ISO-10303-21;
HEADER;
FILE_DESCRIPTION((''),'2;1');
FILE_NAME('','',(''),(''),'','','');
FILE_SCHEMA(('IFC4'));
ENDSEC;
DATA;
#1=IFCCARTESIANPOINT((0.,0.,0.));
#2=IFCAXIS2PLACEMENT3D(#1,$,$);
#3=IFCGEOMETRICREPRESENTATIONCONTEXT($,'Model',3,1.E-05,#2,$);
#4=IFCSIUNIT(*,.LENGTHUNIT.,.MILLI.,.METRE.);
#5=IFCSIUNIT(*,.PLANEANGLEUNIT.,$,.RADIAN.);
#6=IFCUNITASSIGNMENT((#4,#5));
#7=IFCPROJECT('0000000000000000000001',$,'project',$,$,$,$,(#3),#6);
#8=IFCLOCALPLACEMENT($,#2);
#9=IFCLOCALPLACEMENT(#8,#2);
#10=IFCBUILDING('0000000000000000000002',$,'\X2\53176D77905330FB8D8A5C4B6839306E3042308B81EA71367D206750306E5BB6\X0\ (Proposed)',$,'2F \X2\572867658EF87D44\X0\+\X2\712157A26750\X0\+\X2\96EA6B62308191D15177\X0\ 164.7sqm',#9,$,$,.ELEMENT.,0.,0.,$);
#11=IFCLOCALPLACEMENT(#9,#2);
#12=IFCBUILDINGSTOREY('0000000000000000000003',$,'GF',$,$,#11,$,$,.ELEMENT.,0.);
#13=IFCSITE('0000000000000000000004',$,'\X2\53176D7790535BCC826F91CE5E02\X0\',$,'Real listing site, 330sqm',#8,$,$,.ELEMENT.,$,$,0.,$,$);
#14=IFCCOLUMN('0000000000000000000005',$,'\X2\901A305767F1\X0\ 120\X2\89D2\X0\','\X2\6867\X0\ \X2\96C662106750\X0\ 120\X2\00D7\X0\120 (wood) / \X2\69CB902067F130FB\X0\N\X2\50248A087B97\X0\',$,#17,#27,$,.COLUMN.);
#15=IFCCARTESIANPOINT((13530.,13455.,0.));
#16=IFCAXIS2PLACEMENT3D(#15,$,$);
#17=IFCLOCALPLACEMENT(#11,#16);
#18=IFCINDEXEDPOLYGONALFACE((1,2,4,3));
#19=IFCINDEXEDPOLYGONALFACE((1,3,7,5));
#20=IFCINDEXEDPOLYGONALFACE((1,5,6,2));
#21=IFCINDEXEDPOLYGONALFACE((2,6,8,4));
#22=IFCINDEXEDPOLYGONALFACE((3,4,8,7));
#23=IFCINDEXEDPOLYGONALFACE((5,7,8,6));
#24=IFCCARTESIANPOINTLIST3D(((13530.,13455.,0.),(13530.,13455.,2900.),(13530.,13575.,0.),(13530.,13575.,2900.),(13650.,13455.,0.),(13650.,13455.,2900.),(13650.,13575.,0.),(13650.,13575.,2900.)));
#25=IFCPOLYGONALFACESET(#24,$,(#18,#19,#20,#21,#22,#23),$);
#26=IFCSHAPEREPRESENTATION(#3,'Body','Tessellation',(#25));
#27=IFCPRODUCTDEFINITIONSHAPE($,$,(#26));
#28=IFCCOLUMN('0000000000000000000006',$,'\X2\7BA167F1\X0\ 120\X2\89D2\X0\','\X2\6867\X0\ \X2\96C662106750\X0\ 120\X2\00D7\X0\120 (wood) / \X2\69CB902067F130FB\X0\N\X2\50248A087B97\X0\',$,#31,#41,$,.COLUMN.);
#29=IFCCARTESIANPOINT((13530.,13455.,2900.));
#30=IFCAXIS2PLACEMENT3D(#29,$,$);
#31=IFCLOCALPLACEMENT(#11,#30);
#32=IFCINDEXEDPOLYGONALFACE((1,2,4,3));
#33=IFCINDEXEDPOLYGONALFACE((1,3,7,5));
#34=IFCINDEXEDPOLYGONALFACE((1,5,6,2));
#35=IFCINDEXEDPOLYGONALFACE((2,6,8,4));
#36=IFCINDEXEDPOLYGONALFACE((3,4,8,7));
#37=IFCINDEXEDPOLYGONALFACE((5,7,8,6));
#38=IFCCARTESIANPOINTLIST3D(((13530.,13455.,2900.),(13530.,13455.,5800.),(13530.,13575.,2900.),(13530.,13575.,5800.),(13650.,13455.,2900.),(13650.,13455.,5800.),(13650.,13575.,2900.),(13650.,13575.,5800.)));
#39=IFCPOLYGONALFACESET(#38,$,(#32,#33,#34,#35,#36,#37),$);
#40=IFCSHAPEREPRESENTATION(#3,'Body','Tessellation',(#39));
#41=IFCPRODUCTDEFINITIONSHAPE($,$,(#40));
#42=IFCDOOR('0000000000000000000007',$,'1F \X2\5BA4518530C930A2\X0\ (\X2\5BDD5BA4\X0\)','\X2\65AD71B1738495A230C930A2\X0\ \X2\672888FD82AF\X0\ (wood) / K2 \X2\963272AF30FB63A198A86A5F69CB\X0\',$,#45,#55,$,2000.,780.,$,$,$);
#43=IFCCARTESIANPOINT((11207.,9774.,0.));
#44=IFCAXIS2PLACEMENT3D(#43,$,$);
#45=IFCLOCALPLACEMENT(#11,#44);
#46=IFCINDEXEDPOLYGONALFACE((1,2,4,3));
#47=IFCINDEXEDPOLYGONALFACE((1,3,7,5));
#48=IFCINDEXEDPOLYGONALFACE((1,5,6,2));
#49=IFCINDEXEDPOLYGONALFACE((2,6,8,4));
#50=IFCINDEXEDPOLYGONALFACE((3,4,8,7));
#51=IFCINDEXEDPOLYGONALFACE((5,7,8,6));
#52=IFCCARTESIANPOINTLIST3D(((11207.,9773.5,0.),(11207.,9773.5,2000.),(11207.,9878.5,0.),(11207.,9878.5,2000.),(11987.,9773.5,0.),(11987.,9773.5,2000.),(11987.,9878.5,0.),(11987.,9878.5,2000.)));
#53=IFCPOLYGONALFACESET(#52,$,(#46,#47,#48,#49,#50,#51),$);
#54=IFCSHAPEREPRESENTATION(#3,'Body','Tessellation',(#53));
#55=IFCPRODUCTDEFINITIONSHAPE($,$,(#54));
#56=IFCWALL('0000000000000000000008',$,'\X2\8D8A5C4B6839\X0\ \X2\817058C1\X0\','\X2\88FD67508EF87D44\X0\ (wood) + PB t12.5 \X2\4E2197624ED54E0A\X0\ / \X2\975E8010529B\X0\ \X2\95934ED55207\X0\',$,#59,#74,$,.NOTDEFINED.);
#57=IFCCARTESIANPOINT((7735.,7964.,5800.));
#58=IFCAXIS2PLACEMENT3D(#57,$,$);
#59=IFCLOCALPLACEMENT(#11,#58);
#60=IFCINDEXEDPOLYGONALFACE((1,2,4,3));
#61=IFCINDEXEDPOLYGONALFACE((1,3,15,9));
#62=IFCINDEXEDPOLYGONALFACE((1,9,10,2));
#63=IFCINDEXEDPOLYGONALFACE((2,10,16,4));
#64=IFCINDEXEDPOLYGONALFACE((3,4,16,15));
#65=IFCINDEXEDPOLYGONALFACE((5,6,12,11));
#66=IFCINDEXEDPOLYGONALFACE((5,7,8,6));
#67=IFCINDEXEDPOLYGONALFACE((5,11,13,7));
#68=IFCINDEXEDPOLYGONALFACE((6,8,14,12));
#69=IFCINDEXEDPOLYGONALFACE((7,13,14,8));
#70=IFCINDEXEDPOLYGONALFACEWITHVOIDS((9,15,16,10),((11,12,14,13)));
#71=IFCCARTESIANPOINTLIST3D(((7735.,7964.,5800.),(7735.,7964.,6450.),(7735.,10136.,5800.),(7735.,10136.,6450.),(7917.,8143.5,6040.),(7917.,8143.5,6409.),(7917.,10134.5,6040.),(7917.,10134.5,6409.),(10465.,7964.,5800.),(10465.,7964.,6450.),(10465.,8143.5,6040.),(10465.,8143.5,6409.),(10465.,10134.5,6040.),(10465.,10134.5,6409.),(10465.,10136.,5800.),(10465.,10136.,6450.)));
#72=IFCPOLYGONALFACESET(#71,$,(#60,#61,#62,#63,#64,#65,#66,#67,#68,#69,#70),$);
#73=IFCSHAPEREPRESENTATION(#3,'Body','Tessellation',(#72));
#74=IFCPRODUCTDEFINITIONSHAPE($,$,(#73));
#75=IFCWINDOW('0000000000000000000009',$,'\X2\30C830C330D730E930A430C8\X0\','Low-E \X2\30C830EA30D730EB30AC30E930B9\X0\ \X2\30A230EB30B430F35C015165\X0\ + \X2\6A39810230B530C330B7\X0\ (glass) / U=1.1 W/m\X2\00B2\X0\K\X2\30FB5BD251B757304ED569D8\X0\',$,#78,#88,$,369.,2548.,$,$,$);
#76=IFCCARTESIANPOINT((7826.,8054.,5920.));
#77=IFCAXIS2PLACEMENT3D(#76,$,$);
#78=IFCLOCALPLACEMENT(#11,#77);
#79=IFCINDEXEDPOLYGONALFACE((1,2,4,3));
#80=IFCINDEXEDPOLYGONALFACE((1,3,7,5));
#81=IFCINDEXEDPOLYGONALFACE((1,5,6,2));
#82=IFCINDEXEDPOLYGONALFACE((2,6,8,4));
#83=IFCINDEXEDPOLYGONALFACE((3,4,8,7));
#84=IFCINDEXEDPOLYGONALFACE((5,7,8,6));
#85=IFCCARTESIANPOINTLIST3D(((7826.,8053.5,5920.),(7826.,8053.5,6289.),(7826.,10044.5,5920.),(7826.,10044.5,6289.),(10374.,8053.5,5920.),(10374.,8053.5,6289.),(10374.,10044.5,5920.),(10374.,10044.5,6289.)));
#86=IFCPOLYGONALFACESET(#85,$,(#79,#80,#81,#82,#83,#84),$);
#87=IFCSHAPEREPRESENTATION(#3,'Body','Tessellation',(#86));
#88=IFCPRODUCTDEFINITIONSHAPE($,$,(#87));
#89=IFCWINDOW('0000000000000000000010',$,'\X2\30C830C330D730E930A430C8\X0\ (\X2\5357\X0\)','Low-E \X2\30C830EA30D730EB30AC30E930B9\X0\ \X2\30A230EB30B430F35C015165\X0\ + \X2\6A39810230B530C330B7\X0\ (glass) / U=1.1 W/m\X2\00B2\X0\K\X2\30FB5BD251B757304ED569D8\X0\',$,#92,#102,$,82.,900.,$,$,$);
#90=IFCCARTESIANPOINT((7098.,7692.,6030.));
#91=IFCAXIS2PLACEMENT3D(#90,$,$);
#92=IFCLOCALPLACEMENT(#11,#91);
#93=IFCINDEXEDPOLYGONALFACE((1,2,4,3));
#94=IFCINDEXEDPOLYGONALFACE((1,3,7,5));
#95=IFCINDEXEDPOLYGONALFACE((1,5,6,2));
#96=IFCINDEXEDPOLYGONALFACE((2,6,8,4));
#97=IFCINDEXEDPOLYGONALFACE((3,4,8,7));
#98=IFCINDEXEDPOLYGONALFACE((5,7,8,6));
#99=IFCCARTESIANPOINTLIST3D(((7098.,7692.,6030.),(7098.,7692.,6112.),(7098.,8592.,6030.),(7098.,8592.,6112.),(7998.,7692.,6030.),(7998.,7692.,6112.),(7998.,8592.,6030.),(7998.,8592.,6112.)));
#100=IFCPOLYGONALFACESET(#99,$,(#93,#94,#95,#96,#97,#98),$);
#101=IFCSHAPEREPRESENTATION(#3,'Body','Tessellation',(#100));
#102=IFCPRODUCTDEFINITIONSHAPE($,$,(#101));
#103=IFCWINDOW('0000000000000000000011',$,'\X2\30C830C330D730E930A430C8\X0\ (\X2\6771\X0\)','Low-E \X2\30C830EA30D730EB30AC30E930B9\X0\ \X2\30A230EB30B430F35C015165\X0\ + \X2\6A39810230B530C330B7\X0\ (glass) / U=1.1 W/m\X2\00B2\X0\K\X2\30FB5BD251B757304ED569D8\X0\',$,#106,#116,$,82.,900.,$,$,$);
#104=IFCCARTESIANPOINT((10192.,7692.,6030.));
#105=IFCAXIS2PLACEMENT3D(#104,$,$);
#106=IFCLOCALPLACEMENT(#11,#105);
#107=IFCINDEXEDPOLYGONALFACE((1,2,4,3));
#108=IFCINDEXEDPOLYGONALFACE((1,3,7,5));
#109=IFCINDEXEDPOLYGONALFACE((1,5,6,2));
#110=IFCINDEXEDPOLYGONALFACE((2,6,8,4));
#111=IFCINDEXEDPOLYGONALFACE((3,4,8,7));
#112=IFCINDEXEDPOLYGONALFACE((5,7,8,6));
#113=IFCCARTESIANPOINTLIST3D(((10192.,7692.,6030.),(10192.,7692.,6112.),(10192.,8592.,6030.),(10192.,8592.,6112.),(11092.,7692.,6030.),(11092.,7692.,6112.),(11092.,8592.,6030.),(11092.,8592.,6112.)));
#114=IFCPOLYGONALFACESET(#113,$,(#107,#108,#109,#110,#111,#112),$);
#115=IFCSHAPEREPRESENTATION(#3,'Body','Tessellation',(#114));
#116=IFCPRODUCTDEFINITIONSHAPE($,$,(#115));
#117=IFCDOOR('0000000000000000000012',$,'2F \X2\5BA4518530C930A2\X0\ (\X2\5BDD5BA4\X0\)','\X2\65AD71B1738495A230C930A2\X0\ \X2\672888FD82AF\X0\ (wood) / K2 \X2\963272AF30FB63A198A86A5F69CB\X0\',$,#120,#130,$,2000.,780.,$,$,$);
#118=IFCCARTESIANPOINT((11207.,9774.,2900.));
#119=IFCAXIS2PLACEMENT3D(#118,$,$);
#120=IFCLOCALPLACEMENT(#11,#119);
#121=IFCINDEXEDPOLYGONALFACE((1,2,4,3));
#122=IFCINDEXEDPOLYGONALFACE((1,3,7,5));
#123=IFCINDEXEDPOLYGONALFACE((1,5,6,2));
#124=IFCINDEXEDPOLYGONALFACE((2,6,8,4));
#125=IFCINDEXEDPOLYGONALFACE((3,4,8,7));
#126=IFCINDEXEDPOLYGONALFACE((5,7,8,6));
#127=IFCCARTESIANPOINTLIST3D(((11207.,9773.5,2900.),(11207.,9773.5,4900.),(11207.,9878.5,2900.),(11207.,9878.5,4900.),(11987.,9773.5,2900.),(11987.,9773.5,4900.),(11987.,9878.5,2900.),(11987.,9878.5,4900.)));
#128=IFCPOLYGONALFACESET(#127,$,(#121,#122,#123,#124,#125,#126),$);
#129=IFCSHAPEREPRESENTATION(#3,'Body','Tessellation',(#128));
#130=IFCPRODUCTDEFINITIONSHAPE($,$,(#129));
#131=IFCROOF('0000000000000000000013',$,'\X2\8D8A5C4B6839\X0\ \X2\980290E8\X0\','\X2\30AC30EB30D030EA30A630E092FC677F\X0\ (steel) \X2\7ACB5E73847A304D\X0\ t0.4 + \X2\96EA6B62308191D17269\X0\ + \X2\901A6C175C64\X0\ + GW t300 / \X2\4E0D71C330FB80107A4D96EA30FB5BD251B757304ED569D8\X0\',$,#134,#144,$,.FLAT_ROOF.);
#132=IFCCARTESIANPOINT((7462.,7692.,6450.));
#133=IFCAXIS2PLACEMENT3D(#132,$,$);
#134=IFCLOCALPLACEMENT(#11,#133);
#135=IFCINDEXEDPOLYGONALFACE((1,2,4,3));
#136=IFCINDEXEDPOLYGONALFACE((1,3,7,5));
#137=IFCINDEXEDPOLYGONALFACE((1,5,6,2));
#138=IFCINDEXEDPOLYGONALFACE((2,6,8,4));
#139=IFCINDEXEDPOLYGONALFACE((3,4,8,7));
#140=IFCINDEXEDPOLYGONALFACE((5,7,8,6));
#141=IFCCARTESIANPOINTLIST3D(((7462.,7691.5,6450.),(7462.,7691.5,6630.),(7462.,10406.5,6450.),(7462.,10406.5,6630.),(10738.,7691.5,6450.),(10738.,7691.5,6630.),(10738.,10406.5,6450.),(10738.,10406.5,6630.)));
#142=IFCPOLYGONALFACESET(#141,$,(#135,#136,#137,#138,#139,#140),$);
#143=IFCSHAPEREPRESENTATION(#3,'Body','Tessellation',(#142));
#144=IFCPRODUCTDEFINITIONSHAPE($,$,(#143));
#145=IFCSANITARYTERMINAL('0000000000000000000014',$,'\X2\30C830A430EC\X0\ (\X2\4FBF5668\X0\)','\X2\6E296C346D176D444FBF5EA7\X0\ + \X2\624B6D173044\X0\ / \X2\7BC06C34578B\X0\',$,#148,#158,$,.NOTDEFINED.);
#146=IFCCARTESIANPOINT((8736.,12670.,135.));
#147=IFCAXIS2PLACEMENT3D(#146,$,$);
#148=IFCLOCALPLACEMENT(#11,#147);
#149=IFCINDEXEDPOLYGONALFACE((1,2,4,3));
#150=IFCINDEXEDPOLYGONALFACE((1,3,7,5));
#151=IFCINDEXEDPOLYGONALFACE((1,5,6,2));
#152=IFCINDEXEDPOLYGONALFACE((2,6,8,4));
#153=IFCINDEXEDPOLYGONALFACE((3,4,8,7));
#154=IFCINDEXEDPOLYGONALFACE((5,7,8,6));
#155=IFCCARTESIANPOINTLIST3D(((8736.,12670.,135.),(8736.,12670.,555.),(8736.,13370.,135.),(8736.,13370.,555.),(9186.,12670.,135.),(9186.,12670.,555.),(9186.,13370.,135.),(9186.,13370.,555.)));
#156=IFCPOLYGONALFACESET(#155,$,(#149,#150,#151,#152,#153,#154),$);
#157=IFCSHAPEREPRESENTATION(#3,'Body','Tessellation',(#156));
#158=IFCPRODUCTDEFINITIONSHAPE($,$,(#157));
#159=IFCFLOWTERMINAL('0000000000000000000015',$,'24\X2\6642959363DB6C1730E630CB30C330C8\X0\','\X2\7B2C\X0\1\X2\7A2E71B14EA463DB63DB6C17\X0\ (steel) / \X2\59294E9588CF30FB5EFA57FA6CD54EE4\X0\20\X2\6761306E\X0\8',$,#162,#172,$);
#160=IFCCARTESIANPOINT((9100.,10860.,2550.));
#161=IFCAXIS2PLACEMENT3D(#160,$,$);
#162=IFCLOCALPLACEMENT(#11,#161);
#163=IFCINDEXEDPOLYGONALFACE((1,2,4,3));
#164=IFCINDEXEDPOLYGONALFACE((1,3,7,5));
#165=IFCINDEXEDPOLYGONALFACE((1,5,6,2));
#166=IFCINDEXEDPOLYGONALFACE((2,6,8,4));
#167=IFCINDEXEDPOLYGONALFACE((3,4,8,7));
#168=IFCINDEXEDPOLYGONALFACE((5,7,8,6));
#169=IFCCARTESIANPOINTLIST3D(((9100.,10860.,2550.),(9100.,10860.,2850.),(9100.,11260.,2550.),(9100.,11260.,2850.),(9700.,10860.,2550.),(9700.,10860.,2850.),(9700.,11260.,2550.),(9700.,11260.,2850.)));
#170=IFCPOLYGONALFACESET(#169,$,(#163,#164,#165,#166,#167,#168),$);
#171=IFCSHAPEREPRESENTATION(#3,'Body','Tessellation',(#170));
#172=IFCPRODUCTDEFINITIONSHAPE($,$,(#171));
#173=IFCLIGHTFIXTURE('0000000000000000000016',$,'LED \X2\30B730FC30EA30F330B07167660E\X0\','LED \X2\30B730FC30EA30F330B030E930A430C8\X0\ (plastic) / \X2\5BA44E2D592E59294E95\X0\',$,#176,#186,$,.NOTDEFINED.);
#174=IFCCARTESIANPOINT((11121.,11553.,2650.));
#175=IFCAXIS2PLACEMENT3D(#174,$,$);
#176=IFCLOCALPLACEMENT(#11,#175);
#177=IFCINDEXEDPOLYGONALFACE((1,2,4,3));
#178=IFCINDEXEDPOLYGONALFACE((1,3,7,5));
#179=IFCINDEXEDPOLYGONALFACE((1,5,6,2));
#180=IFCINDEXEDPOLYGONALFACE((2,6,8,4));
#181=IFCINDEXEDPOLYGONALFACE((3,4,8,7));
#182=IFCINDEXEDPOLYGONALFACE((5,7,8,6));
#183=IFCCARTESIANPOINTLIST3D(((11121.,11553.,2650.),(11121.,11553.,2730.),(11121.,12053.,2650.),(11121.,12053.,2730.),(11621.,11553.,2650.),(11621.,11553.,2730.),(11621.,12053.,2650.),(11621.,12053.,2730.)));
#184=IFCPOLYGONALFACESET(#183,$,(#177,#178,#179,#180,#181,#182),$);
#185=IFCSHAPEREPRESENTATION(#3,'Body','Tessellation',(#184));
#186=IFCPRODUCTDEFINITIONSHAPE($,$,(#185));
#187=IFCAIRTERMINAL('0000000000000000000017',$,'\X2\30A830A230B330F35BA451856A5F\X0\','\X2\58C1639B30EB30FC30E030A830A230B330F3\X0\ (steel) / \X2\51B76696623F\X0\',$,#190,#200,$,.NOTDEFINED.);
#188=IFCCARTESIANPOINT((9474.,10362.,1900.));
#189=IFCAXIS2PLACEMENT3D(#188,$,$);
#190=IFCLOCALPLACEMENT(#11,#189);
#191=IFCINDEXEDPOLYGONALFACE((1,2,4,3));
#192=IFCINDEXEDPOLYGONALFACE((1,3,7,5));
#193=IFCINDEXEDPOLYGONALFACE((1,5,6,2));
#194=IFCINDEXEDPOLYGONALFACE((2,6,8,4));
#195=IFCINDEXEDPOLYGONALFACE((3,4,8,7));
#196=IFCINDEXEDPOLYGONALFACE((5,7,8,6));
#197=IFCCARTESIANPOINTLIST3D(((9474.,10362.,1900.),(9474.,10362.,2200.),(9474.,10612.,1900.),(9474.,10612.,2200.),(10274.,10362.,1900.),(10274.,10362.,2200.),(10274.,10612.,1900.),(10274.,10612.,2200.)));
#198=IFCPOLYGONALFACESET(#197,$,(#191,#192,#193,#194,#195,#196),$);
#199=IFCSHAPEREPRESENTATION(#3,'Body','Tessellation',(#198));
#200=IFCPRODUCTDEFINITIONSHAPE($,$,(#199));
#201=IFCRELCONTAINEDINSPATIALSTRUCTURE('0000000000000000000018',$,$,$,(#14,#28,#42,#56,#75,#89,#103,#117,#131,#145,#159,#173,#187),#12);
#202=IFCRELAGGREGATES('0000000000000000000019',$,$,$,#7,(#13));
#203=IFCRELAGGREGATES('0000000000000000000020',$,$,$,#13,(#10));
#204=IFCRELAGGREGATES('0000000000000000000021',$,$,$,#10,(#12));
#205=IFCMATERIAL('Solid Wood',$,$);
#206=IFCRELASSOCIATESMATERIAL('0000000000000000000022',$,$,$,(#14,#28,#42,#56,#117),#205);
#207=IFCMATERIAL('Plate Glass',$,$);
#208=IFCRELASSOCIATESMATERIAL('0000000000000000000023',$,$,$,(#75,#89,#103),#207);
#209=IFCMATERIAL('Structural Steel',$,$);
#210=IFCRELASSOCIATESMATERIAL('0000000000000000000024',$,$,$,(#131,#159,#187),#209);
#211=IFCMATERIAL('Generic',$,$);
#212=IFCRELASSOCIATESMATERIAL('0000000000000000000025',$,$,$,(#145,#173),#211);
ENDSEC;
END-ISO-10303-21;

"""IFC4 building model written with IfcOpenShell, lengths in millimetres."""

from ifc_helpers import new_model, si_unit, frame, frame_2d, origin, place, context, project, spatial, rectangle, extrude, material, element, fill, save


model = new_model("IFC4")

# Units and contexts
model_context = context("Model", 3, precision=1e-05, world=origin())
ifc_project = project(units=[si_unit("LENGTHUNIT", "METRE", prefix="MILLI"), si_unit("PLANEANGLEUNIT", "RADIAN")], contexts=[model_context])

# Site, building, storey
site_placement = place(None, origin())
site = spatial("IfcSite", under=ifc_project, at=site_placement, Name="北海道富良野市", ObjectType="Real listing site, 330sqm", CompositionType="ELEMENT", RefElevation=0.0)
building_placement = place(site_placement, origin())
building = spatial("IfcBuilding", under=site, at=building_placement, Name="北海道・越屋根のある自然素材の家 (Proposed)", ObjectType="2F 在来軸組+無垢材+雪止め金具 164.7sqm", CompositionType="ELEMENT", ElevationOfRefHeight=0.0, ElevationOfTerrain=0.0)
storey_placement = place(building_placement, origin())
storey = spatial("IfcBuildingStorey", under=building, at=storey_placement, Name="GF", CompositionType="ELEMENT", Elevation=0.0)

# Columns
ifc_material_1 = material(Name="Solid Wood")
column_1_placement = place(storey_placement, frame((13530.0, 13455.0, 0.0)))
element("IfcColumn", 1, at=column_1_placement, inside=storey, material=ifc_material_1, Name="通し柱 120角", Description="桧 集成材 120×120 (wood) / 構造柱・N値計算", PredefinedType="COLUMN", context=model_context, shape_type="SweptSolid", body=[
    extrude(rectangle(XDim=120.0, YDim=120.0, at=frame_2d((60.0, 60.0))), frame((13530.0, 13455.0, 0.0)), (0.0, 0.0, 1.0), 2900.0),
])
column_2_placement = place(storey_placement, frame((13530.0, 13455.0, 2900.0)))
element("IfcColumn", 2, at=column_2_placement, inside=storey, material=ifc_material_1, Name="管柱 120角", Description="桧 集成材 120×120 (wood) / 構造柱・N値計算", PredefinedType="COLUMN", context=model_context, shape_type="SweptSolid", body=[
    extrude(rectangle(XDim=120.0, YDim=120.0, at=frame_2d((60.0, 60.0))), frame((13530.0, 13455.0, 2900.0)), (0.0, 0.0, 1.0), 2900.0),
])

# Door
door_1_placement = place(storey_placement, frame((11207.0, 9774.0, 0.0)))
element("IfcDoor", 3, at=door_1_placement, inside=storey, material=ifc_material_1, Name="1F 室内ドア (寝室)", Description="断熱玄関ドア 木製芯 (wood) / K2 防犯・採風機構", OverallHeight=2000.0, OverallWidth=780.0, context=model_context, shape_type="SweptSolid", body=[
    extrude(rectangle(XDim=780.0, YDim=105.0, at=frame_2d((390.0, 52.0))), frame((11207.0, 9774.0, 0.0)), (0.0, 0.0, 1.0), 2000.0),
])

# Wall, openings, windows
wall_1_placement = place(storey_placement, frame((7735.0, 7964.0, 5800.0)))
wall_1 = element("IfcWall", 4, at=wall_1_placement, inside=storey, material=ifc_material_1, Name="越屋根 腰壁", Description="製材軸組 (wood) + PB t12.5 両面仕上 / 非耐力 間仕切", PredefinedType="NOTDEFINED", context=model_context, shape_type="SweptSolid", body=[
    extrude(rectangle(XDim=2730.0, YDim=2172.0, at=frame_2d((1365.0, 1086.0))), frame((7735.0, 7964.0, 5800.0)), (0.0, 0.0, 1.0), 650.0),
])
opening_1_placement = place(storey_placement, frame((7826.0, 8054.0, 5920.0)))
opening_1 = element("IfcOpeningElement", 5, at=opening_1_placement, cuts=wall_1, PredefinedType="NOTDEFINED", context=model_context, shape_type="SweptSolid", body=[
    extrude(rectangle(XDim=2548.0, YDim=1991.0, at=frame_2d((1274.0, 995.0))), frame((7826.0, 8054.0, 5920.0)), (0.0, 0.0, 1.0), 369.0),
])
opening_2_placement = place(storey_placement, frame((7098.0, 7692.0, 6030.0)))
opening_2 = element("IfcOpeningElement", 6, at=opening_2_placement, cuts=wall_1, PredefinedType="NOTDEFINED", context=model_context, shape_type="SweptSolid", body=[
    extrude(rectangle(XDim=900.0, YDim=900.0, at=frame_2d((450.0, 450.0))), frame((7098.0, 7692.0, 6030.0)), (0.0, 0.0, 1.0), 82.0),
])
opening_3_placement = place(storey_placement, frame((10192.0, 7692.0, 6030.0)))
opening_3 = element("IfcOpeningElement", 7, at=opening_3_placement, cuts=wall_1, PredefinedType="NOTDEFINED", context=model_context, shape_type="SweptSolid", body=[
    extrude(rectangle(XDim=900.0, YDim=900.0, at=frame_2d((450.0, 450.0))), frame((10192.0, 7692.0, 6030.0)), (0.0, 0.0, 1.0), 82.0),
])
ifc_material_2 = material(Name="Plate Glass")
window_1_placement = place(storey_placement, frame((7826.0, 8054.0, 5920.0)))
window_1 = element("IfcWindow", 8, at=window_1_placement, inside=storey, material=ifc_material_2, Name="トップライト", Description="Low-E トリプルガラス アルゴン封入 + 樹脂サッシ (glass) / U=1.1 W/m²K・寒冷地仕様", OverallHeight=369.0, OverallWidth=2548.0, context=model_context, shape_type="SweptSolid", body=[
    extrude(rectangle(XDim=2548.0, YDim=1991.0, at=frame_2d((1274.0, 995.0))), frame((7826.0, 8054.0, 5920.0)), (0.0, 0.0, 1.0), 369.0),
])
fill(opening_1, window_1)
window_2_placement = place(storey_placement, frame((7098.0, 7692.0, 6030.0)))
window_2 = element("IfcWindow", 9, at=window_2_placement, inside=storey, material=ifc_material_2, Name="トップライト (南)", Description="Low-E トリプルガラス アルゴン封入 + 樹脂サッシ (glass) / U=1.1 W/m²K・寒冷地仕様", OverallHeight=82.0, OverallWidth=900.0, context=model_context, shape_type="SweptSolid", body=[
    extrude(rectangle(XDim=900.0, YDim=900.0, at=frame_2d((450.0, 450.0))), frame((7098.0, 7692.0, 6030.0)), (0.0, 0.0, 1.0), 82.0),
])
fill(opening_2, window_2)
window_3_placement = place(storey_placement, frame((10192.0, 7692.0, 6030.0)))
window_3 = element("IfcWindow", 10, at=window_3_placement, inside=storey, material=ifc_material_2, Name="トップライト (東)", Description="Low-E トリプルガラス アルゴン封入 + 樹脂サッシ (glass) / U=1.1 W/m²K・寒冷地仕様", OverallHeight=82.0, OverallWidth=900.0, context=model_context, shape_type="SweptSolid", body=[
    extrude(rectangle(XDim=900.0, YDim=900.0, at=frame_2d((450.0, 450.0))), frame((10192.0, 7692.0, 6030.0)), (0.0, 0.0, 1.0), 82.0),
])
fill(opening_3, window_3)

# Door
door_2_placement = place(storey_placement, frame((11207.0, 9774.0, 2900.0)))
element("IfcDoor", 11, at=door_2_placement, inside=storey, material=ifc_material_1, Name="2F 室内ドア (寝室)", Description="断熱玄関ドア 木製芯 (wood) / K2 防犯・採風機構", OverallHeight=2000.0, OverallWidth=780.0, context=model_context, shape_type="SweptSolid", body=[
    extrude(rectangle(XDim=780.0, YDim=105.0, at=frame_2d((390.0, 52.0))), frame((11207.0, 9774.0, 2900.0)), (0.0, 0.0, 1.0), 2000.0),
])

# Roof
ifc_material_3 = material(Name="Structural Steel")
roof_placement = place(storey_placement, frame((7462.0, 7692.0, 6450.0)))
element("IfcRoof", 12, at=roof_placement, inside=storey, material=ifc_material_3, Name="越屋根 頂部", Description="ガルバリウム鋼板 (steel) 立平葺き t0.4 + 雪止め金物 + 通気層 + GW t300 / 不燃・耐積雪・寒冷地仕様", PredefinedType="FLAT_ROOF", context=model_context, shape_type="SweptSolid", body=[
    extrude(rectangle(XDim=3276.0, YDim=2715.0, at=frame_2d((1638.0, 1357.0))), frame((7462.0, 7692.0, 6450.0)), (0.0, 0.0, 1.0), 180.0),
])

# Sanitary terminal
ifc_material_4 = material(Name="Generic")
sanitary_terminal_placement = place(storey_placement, frame((8736.0, 12670.0, 135.0)))
element("IfcSanitaryTerminal", 13, at=sanitary_terminal_placement, inside=storey, material=ifc_material_4, Name="トイレ (便器)", Description="温水洗浄便座 + 手洗い / 節水型", PredefinedType="NOTDEFINED", context=model_context, shape_type="SweptSolid", body=[
    extrude(rectangle(XDim=450.0, YDim=700.0, at=frame_2d((225.0, 350.0))), frame((8736.0, 12670.0, 135.0)), (0.0, 0.0, 1.0), 420.0),
])

# Flow terminal
flow_terminal_placement = place(storey_placement, frame((9100.0, 10860.0, 2550.0)))
element("IfcFlowTerminal", 14, at=flow_terminal_placement, inside=storey, material=ifc_material_3, Name="24時間換気ユニット", Description="第1種熱交換換気 (steel) / 天井裏・建基法令20条の8", context=model_context, shape_type="SweptSolid", body=[
    extrude(rectangle(XDim=600.0, YDim=400.0, at=frame_2d((300.0, 200.0))), frame((9100.0, 10860.0, 2550.0)), (0.0, 0.0, 1.0), 300.0),
])

# Light fixture
light_fixture_1_placement = place(storey_placement, frame((11121.0, 11553.0, 2650.0)))
element("IfcLightFixture", 15, at=light_fixture_1_placement, inside=storey, material=ifc_material_4, Name="LED シーリング照明", Description="LED シーリングライト (plastic) / 室中央天井", PredefinedType="NOTDEFINED", context=model_context, shape_type="SweptSolid", body=[
    extrude(rectangle(XDim=500.0, YDim=500.0, at=frame_2d((250.0, 250.0))), frame((11121.0, 11553.0, 2650.0)), (0.0, 0.0, 1.0), 80.0),
])

# Air terminal
air_terminal_placement = place(storey_placement, frame((9474.0, 10362.0, 1900.0)))
element("IfcAirTerminal", 16, at=air_terminal_placement, inside=storey, material=ifc_material_3, Name="エアコン室内機", Description="壁掛ルームエアコン (steel) / 冷暖房", PredefinedType="NOTDEFINED", context=model_context, shape_type="SweptSolid", body=[
    extrude(rectangle(XDim=800.0, YDim=250.0, at=frame_2d((400.0, 125.0))), frame((9474.0, 10362.0, 1900.0)), (0.0, 0.0, 1.0), 300.0),
])

save(model, "model.ifc")
